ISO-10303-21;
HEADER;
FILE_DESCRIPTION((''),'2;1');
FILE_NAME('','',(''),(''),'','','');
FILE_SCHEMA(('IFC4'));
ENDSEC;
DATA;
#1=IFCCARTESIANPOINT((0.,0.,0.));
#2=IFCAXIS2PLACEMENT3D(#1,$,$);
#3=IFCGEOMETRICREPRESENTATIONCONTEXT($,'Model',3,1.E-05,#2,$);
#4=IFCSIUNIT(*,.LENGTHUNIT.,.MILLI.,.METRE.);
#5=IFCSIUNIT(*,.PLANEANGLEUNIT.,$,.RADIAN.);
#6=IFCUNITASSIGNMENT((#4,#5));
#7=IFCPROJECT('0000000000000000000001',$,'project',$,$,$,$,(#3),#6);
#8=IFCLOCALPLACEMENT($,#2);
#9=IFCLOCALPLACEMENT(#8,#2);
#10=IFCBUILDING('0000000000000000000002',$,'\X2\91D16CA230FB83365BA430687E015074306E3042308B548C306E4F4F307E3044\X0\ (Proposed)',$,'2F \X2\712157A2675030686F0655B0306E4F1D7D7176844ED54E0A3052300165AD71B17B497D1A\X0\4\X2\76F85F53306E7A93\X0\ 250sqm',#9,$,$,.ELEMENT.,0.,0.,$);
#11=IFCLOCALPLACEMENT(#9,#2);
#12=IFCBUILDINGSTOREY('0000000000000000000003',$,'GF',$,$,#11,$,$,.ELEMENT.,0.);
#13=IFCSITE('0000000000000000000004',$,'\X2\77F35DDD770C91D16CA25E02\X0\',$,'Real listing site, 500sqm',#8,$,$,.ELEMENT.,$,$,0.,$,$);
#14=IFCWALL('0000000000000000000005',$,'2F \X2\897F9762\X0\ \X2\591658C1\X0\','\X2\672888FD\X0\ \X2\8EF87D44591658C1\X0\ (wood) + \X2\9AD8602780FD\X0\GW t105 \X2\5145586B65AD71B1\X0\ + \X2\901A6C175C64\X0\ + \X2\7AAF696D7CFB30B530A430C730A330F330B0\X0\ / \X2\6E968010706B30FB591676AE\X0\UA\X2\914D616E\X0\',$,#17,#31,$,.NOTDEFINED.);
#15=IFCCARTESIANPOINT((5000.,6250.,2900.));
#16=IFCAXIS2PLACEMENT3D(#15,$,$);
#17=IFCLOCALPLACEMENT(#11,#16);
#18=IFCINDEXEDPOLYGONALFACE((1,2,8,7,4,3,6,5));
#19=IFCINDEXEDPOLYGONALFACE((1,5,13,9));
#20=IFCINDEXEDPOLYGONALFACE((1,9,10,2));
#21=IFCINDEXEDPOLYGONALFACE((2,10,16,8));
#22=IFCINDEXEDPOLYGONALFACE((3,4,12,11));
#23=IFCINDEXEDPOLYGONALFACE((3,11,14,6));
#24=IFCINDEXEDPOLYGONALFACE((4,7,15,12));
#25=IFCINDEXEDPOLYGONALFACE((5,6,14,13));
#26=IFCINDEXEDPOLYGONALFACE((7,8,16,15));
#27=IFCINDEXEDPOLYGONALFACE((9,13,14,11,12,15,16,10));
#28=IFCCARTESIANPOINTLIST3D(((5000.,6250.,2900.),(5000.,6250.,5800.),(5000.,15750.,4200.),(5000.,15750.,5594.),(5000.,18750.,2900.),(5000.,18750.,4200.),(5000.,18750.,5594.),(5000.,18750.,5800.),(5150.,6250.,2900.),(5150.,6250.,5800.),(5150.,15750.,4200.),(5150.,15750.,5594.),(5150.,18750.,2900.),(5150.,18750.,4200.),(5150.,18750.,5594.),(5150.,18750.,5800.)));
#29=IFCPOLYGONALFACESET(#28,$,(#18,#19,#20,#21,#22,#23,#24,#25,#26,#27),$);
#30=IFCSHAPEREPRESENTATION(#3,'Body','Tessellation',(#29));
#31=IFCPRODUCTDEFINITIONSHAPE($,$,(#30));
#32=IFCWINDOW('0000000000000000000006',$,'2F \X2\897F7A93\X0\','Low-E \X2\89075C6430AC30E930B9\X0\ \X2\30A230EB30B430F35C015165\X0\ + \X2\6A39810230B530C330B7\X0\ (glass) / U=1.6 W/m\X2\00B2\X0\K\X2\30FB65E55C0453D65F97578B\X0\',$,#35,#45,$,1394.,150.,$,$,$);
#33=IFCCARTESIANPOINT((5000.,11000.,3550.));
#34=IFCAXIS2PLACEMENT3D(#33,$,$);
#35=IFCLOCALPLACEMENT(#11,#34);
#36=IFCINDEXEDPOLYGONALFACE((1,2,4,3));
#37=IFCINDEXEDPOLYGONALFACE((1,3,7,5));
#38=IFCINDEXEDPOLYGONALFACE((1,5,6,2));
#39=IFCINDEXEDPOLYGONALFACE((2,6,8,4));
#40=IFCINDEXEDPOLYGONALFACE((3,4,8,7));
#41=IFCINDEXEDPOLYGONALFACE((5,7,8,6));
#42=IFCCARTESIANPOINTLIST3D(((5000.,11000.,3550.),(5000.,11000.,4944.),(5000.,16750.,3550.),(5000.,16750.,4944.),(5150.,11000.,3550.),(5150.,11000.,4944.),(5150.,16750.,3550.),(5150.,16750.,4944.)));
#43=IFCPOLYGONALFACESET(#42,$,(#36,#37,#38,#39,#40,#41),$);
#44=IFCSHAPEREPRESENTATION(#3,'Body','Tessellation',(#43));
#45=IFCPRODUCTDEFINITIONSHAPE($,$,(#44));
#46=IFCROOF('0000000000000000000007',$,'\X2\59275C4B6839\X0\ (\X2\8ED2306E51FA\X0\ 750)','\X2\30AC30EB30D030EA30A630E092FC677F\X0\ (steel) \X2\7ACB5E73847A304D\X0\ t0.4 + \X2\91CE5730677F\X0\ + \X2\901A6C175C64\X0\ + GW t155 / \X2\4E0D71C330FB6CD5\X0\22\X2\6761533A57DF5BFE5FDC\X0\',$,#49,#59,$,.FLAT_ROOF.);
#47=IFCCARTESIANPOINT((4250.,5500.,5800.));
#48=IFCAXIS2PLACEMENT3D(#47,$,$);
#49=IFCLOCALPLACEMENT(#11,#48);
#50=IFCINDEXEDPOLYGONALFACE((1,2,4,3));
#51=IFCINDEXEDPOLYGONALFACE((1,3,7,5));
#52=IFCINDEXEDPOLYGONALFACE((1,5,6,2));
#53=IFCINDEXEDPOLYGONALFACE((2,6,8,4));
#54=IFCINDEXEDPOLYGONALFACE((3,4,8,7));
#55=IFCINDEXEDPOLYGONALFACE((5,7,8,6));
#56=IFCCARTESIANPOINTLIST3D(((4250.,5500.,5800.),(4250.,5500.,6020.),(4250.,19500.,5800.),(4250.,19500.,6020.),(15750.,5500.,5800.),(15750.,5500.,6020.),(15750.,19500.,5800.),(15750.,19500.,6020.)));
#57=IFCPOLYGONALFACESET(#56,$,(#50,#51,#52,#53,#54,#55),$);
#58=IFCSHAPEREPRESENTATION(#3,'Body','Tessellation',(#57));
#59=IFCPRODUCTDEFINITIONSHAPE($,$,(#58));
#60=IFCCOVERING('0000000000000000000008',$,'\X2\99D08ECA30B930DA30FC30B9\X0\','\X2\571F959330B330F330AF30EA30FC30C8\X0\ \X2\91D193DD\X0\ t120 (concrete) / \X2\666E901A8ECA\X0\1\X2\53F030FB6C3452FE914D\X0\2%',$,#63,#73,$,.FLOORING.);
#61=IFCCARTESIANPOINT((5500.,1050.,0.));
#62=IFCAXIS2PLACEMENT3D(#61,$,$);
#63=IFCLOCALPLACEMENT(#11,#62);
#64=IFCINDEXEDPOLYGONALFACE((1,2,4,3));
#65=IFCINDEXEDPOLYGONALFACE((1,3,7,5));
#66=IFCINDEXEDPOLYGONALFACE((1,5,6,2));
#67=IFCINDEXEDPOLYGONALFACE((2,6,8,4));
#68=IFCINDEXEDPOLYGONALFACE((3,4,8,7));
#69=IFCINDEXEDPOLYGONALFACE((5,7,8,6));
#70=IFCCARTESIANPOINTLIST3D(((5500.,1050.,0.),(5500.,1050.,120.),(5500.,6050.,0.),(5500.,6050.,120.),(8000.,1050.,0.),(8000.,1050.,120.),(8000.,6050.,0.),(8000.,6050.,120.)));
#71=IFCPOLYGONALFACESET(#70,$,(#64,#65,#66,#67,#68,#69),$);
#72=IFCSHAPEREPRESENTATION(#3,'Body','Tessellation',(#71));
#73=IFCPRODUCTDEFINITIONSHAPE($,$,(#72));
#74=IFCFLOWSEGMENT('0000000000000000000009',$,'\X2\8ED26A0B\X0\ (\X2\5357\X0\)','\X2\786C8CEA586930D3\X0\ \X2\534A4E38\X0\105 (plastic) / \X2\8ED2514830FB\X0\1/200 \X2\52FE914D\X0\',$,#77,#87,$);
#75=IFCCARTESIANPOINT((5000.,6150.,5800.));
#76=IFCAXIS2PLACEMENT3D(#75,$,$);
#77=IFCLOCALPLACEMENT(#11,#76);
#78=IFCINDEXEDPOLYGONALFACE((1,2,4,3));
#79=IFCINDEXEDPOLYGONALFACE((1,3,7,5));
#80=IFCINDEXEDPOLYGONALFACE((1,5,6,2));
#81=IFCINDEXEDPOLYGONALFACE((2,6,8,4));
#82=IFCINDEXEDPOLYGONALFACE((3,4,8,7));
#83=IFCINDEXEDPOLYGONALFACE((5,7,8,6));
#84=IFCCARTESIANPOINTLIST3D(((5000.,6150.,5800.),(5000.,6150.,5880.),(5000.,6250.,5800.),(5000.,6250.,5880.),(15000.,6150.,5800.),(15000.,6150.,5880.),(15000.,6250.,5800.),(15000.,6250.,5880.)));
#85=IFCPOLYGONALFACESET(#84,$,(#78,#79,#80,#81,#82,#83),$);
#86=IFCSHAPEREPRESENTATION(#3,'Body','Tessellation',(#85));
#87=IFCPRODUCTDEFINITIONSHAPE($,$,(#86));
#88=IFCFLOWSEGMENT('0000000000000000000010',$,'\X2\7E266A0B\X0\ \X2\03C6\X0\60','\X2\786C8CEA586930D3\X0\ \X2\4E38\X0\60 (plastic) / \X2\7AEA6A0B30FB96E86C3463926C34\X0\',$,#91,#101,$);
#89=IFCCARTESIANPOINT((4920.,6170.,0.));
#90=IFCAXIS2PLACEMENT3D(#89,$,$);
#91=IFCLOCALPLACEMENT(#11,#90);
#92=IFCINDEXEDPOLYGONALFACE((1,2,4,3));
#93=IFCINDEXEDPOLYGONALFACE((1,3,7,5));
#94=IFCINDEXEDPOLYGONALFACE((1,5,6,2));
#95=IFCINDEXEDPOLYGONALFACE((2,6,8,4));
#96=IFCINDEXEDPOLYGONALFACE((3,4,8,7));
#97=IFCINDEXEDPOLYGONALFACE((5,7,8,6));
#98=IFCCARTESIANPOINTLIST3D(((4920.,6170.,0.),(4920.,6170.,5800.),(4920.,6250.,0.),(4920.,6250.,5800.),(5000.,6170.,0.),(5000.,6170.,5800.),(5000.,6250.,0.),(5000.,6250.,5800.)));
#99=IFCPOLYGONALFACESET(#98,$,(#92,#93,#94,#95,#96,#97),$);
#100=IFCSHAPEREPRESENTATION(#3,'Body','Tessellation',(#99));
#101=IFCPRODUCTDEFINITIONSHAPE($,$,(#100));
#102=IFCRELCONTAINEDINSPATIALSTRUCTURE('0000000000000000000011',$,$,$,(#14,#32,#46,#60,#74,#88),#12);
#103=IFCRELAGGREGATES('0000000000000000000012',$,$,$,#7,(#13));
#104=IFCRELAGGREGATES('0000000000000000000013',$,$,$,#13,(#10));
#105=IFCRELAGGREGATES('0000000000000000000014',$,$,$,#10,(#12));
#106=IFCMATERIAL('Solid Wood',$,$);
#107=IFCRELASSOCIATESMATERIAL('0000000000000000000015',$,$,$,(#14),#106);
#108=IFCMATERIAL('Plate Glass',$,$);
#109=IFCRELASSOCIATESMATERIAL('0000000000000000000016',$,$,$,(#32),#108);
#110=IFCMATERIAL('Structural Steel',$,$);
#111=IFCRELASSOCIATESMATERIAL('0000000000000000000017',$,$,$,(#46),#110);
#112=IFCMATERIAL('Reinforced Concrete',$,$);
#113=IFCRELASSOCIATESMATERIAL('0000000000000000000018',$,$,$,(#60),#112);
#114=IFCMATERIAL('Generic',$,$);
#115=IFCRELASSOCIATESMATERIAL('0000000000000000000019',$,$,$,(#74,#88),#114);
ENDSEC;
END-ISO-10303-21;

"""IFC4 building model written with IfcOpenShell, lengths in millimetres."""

from ifc_helpers import new_model, si_unit, frame, frame_2d, origin, place, context, project, spatial, rectangle, extrude, material, element, fill, save


model = new_model("IFC4")

# Units and contexts
model_context = context("Model", 3, precision=1e-05, world=origin())
ifc_project = project(units=[si_unit("LENGTHUNIT", "METRE", prefix="MILLI"), si_unit("PLANEANGLEUNIT", "RADIAN")], contexts=[model_context])

# Site, building, storey
site_placement = place(None, origin())
site = spatial("IfcSite", under=ifc_project, at=site_placement, Name="石川県金沢市", ObjectType="Real listing site, 500sqm", CompositionType="ELEMENT", RefElevation=0.0)
building_placement = place(site_placement, origin())
building = spatial("IfcBuilding", under=site, at=building_placement, Name="金沢・茶室と縁側のある和の住まい (Proposed)", ObjectType="2F 無垢材と漆喰の伝統的仕上げ、断熱等級4相当の窓 250sqm", CompositionType="ELEMENT", ElevationOfRefHeight=0.0, ElevationOfTerrain=0.0)
storey_placement = place(building_placement, origin())
storey = spatial("IfcBuildingStorey", under=building, at=storey_placement, Name="GF", CompositionType="ELEMENT", Elevation=0.0)

# Shared definitions
ifc_material_1 = material(Name="Solid Wood")

# Shared definitions
ifc_material_2 = material(Name="Reinforced Concrete")

# Shared definitions
ifc_material_3 = material(Name="Plate Glass")

# Wall, opening, window
wall_1_placement = place(storey_placement, frame((5000.0, 6250.0, 2900.0)))
wall_1 = element("IfcWall", 1, at=wall_1_placement, inside=storey, material=ifc_material_1, Name="2F 西面 外壁", Description="木製 軸組外壁 (wood) + 高性能GW t105 充填断熱 + 通気層 + 窯業系サイディング / 準耐火・外皮UA配慮", PredefinedType="NOTDEFINED", context=model_context, shape_type="SweptSolid", body=[
    extrude(rectangle(XDim=150.0, YDim=12500.0, at=frame_2d((75.0, 6250.0))), frame((5000.0, 6250.0, 2900.0)), (0.0, 0.0, 1.0), 2900.0),
])
opening_1_placement = place(storey_placement, frame((5000.0, 11000.0, 3550.0)))
opening_1 = element("IfcOpeningElement", 2, at=opening_1_placement, cuts=wall_1, PredefinedType="NOTDEFINED", context=model_context, shape_type="SweptSolid", body=[
    extrude(rectangle(XDim=150.0, YDim=5750.0, at=frame_2d((75.0, 2875.0))), frame((5000.0, 11000.0, 3550.0)), (0.0, 0.0, 1.0), 1394.0),
])
window_1_placement = place(storey_placement, frame((5000.0, 11000.0, 3550.0)))
window_1 = element("IfcWindow", 3, at=window_1_placement, inside=storey, material=ifc_material_3, Name="2F 西窓", Description="Low-E 複層ガラス アルゴン封入 + 樹脂サッシ (glass) / U=1.6 W/m²K・日射取得型", OverallHeight=1394.0, OverallWidth=150.0, context=model_context, shape_type="SweptSolid", body=[
    extrude(rectangle(XDim=150.0, YDim=5750.0, at=frame_2d((75.0, 2875.0))), frame((5000.0, 11000.0, 3550.0)), (0.0, 0.0, 1.0), 1394.0),
])
fill(opening_1, window_1)

# Roof
ifc_material_4 = material(Name="Structural Steel")
roof_placement = place(storey_placement, frame((4250.0, 5500.0, 5800.0)))
element("IfcRoof", 4, at=roof_placement, inside=storey, material=ifc_material_4, Name="大屋根 (軒の出 750)", Description="ガルバリウム鋼板 (steel) 立平葺き t0.4 + 野地板 + 通気層 + GW t155 / 不燃・法22条区域対応", PredefinedType="FLAT_ROOF", context=model_context, shape_type="SweptSolid", body=[
    extrude(rectangle(XDim=11500.0, YDim=14000.0, at=frame_2d((5750.0, 7000.0))), frame((4250.0, 5500.0, 5800.0)), (0.0, 0.0, 1.0), 220.0),
])

# Covering
covering_placement = place(storey_placement, frame((5500.0, 1050.0, 0.0)))
element("IfcCovering", 5, at=covering_placement, inside=storey, material=ifc_material_2, Name="駐車スペース", Description="土間コンクリート 金鏝 t120 (concrete) / 普通車1台・水勾配2%", PredefinedType="FLOORING", context=model_context, shape_type="SweptSolid", body=[
    extrude(rectangle(XDim=2500.0, YDim=5000.0, at=frame_2d((1250.0, 2500.0))), frame((5500.0, 1050.0, 0.0)), (0.0, 0.0, 1.0), 120.0),
])

# Flow segments
ifc_material_5 = material(Name="Generic")
flow_segment_1_placement = place(storey_placement, frame((5000.0, 6150.0, 5800.0)))
element("IfcFlowSegment", 6, at=flow_segment_1_placement, inside=storey, material=ifc_material_5, Name="軒樋 (南)", Description="硬質塩ビ 半丸105 (plastic) / 軒先・1/200 勾配", context=model_context, shape_type="SweptSolid", body=[
    extrude(rectangle(XDim=10000.0, YDim=100.0, at=frame_2d((5000.0, 50.0))), frame((5000.0, 6150.0, 5800.0)), (0.0, 0.0, 1.0), 80.0),
])
flow_segment_2_placement = place(storey_placement, frame((4920.0, 6170.0, 0.0)))
element("IfcFlowSegment", 7, at=flow_segment_2_placement, inside=storey, material=ifc_material_5, Name="縦樋 φ60", Description="硬質塩ビ 丸60 (plastic) / 竪樋・雨水排水", context=model_context, shape_type="SweptSolid", body=[
    extrude(rectangle(XDim=80.0, YDim=80.0, at=frame_2d((40.0, 40.0))), frame((4920.0, 6170.0, 0.0)), (0.0, 0.0, 1.0), 5800.0),
])

save(model, "model.ifc")
